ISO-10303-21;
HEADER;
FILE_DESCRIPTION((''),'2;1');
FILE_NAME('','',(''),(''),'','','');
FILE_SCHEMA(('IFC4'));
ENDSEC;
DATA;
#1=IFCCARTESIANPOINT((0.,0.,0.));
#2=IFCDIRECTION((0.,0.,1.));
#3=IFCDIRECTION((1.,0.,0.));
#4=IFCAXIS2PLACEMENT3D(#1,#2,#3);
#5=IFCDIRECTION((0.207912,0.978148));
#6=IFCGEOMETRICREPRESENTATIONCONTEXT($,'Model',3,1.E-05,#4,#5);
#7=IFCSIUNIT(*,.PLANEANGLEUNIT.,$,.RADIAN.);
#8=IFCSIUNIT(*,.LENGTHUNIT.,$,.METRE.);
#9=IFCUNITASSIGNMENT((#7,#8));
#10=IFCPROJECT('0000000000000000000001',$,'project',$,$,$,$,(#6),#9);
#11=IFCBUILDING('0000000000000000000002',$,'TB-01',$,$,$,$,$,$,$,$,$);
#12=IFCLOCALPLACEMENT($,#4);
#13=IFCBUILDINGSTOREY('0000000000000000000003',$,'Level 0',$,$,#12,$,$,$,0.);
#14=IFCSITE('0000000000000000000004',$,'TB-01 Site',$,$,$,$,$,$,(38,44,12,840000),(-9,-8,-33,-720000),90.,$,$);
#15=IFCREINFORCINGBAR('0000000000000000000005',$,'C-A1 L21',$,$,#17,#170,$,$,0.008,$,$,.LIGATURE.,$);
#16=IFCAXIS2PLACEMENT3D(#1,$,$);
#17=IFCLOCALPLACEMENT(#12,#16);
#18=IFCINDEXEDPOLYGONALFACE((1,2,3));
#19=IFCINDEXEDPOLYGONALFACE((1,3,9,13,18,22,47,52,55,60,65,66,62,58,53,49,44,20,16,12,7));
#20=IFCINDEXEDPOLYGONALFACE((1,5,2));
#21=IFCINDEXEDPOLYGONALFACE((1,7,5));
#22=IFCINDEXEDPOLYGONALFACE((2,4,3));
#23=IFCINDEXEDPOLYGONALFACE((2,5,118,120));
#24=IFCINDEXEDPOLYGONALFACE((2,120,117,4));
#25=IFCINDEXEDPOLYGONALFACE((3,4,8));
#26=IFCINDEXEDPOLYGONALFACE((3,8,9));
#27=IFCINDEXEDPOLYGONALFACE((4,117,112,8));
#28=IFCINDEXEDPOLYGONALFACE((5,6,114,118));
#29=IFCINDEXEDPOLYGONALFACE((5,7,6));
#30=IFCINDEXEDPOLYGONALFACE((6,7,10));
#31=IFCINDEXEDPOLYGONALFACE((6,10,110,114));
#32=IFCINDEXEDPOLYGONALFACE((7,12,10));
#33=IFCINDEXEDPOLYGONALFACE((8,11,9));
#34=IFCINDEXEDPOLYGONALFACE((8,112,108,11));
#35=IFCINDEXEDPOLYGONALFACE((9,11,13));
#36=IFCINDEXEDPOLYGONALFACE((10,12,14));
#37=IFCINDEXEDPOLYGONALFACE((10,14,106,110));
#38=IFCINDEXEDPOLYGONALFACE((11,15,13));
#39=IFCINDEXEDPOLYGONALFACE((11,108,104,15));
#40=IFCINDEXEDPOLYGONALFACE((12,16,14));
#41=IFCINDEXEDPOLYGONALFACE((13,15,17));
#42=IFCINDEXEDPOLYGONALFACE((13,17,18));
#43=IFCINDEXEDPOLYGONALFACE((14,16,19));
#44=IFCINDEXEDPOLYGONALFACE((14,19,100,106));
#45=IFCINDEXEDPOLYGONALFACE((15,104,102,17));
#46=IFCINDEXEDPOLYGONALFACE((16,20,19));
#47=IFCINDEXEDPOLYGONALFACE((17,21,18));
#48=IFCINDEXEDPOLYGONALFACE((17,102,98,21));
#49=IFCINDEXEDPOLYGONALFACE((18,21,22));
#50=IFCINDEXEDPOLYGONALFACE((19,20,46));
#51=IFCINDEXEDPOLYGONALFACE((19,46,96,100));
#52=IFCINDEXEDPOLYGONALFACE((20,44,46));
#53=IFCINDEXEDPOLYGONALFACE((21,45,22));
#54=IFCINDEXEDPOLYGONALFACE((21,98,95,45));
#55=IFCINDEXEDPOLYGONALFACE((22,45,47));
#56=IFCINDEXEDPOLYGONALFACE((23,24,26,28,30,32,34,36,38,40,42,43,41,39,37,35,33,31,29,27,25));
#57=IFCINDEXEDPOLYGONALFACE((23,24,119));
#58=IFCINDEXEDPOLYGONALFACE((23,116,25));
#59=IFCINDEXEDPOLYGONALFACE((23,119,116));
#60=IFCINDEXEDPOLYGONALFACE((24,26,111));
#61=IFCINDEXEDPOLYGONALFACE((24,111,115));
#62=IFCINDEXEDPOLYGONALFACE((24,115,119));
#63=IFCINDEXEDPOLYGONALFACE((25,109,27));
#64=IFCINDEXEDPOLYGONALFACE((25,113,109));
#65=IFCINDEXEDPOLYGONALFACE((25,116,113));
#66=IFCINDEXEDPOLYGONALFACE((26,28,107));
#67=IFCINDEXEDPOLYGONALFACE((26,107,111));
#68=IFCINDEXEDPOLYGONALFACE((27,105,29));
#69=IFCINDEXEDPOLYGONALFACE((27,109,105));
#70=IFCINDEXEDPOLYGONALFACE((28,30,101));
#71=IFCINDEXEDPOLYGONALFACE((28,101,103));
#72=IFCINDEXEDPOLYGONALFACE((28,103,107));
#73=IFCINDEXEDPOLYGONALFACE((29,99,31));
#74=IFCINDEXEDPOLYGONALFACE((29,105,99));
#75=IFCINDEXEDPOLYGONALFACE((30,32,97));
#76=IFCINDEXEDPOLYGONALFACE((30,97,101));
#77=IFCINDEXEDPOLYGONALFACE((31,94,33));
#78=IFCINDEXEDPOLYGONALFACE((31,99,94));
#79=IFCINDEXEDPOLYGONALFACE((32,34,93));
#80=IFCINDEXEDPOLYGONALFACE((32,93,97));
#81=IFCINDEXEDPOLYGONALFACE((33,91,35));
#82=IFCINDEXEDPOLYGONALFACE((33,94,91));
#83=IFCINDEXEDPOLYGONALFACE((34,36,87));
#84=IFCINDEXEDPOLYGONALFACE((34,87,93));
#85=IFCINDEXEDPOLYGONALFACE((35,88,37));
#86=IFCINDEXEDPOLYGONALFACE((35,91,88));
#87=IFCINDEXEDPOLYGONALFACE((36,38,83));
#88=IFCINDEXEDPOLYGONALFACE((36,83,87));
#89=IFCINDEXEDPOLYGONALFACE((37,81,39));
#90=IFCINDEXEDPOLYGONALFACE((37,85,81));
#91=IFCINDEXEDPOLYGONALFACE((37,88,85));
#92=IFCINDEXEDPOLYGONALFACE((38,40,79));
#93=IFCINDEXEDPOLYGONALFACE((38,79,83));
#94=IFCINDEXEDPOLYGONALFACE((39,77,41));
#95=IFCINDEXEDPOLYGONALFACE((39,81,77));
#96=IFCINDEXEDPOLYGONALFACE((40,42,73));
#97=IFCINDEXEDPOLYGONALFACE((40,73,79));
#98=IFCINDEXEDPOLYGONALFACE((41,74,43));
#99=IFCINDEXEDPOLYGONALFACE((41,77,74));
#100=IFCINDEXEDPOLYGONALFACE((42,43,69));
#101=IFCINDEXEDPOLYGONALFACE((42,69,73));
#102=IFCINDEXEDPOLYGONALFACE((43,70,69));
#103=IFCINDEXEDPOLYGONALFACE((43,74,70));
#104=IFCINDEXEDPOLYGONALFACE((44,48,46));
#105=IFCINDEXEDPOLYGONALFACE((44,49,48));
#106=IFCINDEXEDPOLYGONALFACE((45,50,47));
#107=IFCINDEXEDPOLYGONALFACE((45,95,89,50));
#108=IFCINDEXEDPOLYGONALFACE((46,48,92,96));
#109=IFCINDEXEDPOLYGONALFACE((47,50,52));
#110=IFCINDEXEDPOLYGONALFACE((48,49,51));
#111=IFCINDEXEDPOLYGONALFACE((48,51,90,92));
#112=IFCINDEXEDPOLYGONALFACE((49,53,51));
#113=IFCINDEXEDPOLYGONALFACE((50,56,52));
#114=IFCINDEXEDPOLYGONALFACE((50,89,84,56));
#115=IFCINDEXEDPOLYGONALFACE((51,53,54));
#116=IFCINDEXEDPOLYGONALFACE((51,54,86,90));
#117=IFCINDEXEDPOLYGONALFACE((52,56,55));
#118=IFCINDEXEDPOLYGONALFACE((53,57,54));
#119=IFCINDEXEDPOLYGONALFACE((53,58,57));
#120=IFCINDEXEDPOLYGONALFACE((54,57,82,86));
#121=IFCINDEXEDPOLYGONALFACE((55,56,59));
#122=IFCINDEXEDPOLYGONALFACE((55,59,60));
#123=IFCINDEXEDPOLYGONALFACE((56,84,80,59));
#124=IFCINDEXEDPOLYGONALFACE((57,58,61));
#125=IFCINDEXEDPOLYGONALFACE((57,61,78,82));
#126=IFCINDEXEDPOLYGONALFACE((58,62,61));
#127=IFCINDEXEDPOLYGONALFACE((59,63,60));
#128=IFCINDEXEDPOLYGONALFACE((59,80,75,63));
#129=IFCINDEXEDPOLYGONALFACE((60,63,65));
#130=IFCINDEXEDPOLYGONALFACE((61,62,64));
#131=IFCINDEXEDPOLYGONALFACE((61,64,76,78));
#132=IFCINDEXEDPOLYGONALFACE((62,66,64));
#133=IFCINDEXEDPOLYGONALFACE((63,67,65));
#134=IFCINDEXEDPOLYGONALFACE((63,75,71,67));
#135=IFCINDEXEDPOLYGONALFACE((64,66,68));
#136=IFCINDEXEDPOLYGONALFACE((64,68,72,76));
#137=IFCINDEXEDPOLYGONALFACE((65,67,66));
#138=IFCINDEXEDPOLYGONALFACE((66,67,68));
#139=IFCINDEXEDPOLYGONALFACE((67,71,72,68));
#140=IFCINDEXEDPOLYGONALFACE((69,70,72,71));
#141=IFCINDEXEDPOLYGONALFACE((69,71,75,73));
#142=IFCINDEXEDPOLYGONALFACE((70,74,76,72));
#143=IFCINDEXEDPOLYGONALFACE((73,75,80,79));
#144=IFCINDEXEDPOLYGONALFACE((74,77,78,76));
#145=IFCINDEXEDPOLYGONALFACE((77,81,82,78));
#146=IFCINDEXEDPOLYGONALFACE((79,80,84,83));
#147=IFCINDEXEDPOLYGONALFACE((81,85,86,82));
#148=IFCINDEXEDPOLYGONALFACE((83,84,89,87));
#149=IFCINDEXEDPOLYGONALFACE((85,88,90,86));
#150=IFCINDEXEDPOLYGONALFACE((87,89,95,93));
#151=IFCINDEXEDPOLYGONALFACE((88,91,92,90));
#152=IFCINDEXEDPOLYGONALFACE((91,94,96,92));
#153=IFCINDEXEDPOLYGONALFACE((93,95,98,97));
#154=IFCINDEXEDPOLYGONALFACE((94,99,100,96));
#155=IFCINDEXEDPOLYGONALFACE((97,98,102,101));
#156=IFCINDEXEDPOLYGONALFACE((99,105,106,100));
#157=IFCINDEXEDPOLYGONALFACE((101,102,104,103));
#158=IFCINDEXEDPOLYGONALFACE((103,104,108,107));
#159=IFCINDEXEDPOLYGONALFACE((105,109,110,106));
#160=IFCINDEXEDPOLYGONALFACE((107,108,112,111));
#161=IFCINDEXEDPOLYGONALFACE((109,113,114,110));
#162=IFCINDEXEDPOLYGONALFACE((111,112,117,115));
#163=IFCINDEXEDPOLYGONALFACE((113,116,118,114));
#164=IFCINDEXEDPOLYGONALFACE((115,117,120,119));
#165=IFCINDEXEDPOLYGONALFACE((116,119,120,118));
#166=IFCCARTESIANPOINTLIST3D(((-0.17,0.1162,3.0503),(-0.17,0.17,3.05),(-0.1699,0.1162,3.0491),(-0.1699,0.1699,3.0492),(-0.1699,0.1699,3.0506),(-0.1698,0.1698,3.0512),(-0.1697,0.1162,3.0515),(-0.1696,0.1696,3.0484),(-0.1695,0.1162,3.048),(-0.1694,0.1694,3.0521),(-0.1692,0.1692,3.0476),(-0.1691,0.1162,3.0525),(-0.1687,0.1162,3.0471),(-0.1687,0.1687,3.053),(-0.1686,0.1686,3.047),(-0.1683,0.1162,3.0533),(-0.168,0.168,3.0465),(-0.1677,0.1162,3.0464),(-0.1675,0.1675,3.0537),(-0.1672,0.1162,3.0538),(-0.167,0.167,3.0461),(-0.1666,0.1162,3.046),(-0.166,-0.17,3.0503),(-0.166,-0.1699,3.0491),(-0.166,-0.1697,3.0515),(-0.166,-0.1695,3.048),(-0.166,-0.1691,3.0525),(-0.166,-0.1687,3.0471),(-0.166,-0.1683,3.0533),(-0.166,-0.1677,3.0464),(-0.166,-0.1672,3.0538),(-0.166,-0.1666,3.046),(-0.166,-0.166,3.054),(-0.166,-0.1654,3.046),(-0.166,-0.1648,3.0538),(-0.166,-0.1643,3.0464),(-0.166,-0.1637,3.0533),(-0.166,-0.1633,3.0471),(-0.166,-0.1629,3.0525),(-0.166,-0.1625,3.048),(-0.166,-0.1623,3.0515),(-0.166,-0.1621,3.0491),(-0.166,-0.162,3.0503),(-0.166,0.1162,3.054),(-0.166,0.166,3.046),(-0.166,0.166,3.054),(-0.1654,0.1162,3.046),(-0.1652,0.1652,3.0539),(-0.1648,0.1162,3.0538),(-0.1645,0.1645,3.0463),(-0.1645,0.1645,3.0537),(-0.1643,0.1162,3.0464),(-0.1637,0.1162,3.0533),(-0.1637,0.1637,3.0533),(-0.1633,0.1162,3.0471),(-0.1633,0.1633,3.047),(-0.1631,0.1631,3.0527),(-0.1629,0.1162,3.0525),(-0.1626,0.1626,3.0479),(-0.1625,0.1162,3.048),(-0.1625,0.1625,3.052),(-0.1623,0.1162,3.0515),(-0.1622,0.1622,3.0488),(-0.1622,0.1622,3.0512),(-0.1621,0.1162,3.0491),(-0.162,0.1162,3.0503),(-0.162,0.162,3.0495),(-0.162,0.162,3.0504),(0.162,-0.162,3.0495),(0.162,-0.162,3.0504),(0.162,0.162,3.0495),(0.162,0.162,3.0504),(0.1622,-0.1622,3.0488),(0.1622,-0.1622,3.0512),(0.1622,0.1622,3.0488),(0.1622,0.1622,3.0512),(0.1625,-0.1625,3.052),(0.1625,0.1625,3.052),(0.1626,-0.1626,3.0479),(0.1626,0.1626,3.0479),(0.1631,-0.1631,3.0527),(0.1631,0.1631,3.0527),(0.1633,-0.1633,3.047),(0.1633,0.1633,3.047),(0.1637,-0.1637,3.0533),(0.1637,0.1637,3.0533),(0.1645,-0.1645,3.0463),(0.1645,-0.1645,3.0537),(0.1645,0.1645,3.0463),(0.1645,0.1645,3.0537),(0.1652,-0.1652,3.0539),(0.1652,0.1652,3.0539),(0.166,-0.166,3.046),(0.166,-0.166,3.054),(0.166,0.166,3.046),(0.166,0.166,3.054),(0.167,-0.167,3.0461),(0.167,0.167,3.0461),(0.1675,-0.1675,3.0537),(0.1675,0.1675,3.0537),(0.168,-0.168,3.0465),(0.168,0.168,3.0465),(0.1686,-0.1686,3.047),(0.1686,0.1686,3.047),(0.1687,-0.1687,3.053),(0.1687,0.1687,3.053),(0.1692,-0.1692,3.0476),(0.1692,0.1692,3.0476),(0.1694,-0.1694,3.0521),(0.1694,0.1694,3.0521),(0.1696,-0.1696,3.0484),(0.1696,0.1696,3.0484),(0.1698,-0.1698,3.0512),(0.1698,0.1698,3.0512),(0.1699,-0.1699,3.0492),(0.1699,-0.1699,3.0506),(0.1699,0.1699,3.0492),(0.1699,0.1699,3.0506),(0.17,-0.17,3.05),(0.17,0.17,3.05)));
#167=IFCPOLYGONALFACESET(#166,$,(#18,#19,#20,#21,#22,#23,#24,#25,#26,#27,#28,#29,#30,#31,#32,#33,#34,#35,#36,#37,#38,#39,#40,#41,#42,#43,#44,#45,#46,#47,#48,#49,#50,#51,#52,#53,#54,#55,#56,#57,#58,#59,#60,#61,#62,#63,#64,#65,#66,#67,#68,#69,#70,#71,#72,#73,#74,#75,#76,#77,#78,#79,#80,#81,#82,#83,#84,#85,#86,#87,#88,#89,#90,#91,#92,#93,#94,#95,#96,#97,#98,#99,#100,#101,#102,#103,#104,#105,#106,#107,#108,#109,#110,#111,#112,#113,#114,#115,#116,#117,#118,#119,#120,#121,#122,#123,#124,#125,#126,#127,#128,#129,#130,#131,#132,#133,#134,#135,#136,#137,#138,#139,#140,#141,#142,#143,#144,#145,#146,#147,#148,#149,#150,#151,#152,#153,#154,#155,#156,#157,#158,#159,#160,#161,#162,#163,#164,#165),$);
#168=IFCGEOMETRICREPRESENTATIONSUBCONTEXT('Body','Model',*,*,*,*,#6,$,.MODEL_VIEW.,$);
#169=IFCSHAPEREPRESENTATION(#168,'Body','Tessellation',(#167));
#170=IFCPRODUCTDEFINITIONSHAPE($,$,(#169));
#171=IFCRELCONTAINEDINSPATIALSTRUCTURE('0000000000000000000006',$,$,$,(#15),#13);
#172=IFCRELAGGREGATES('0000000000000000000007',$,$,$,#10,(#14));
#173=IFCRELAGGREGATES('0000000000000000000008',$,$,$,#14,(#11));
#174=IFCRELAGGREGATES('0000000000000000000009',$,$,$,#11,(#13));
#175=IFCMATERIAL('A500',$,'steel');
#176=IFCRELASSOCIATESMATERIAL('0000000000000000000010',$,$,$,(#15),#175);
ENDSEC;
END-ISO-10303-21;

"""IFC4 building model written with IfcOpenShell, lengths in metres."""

from ifc_helpers import new_model, entity, si_unit, direction, origin_with_axes, place, context, subcontext, project, spatial, material, element, save


model = new_model("IFC4")

# Units and contexts
model_context = context("Model", 3, precision=1e-05, world=origin_with_axes(), true_north=direction((0.207912, 0.978148)))
body_context = subcontext(model_context, "Body", "Model", "MODEL_VIEW")
ifc_project = project(units=[si_unit("PLANEANGLEUNIT", "RADIAN"), si_unit("LENGTHUNIT", "METRE")], contexts=[model_context])

# Site, building, storey
site = spatial("IfcSite", under=ifc_project, Name="TB-01 Site", RefLatitude=(38, 44, 12, 840000), RefLongitude=(-9, -8, -33, -720000), RefElevation=90.0)
building = spatial("IfcBuilding", under=site, Name="TB-01")
storey_placement = place(None, origin_with_axes())
storey = spatial("IfcBuildingStorey", under=building, at=storey_placement, Name="Level 0", Elevation=0.0)

# Reinforcing bar
ifc_material_1 = material(Name="A500", Category="steel")
reinforcing_bar_1_placement = place(storey_placement, origin_with_axes())
element("IfcReinforcingBar", 1, at=reinforcing_bar_1_placement, inside=storey, material=ifc_material_1, Name="C-A1 L21", NominalDiameter=0.008, PredefinedType="LIGATURE", context=body_context, shape_type="AdvancedSweptSolid", body=[
    entity("IfcSweptDiskSolid", entity("IfcPolyline", [entity("IfcCartesianPoint", [-0.166, -0.166, 3.05]), entity("IfcCartesianPoint", [0.166, -0.166, 3.05]), entity("IfcCartesianPoint", [0.166, 0.166, 3.05]), entity("IfcCartesianPoint", [-0.166, 0.166, 3.05]), entity("IfcCartesianPoint", [-0.166, 0.1162, 3.05])]), 0.004),
])

save(model, "model.ifc")
